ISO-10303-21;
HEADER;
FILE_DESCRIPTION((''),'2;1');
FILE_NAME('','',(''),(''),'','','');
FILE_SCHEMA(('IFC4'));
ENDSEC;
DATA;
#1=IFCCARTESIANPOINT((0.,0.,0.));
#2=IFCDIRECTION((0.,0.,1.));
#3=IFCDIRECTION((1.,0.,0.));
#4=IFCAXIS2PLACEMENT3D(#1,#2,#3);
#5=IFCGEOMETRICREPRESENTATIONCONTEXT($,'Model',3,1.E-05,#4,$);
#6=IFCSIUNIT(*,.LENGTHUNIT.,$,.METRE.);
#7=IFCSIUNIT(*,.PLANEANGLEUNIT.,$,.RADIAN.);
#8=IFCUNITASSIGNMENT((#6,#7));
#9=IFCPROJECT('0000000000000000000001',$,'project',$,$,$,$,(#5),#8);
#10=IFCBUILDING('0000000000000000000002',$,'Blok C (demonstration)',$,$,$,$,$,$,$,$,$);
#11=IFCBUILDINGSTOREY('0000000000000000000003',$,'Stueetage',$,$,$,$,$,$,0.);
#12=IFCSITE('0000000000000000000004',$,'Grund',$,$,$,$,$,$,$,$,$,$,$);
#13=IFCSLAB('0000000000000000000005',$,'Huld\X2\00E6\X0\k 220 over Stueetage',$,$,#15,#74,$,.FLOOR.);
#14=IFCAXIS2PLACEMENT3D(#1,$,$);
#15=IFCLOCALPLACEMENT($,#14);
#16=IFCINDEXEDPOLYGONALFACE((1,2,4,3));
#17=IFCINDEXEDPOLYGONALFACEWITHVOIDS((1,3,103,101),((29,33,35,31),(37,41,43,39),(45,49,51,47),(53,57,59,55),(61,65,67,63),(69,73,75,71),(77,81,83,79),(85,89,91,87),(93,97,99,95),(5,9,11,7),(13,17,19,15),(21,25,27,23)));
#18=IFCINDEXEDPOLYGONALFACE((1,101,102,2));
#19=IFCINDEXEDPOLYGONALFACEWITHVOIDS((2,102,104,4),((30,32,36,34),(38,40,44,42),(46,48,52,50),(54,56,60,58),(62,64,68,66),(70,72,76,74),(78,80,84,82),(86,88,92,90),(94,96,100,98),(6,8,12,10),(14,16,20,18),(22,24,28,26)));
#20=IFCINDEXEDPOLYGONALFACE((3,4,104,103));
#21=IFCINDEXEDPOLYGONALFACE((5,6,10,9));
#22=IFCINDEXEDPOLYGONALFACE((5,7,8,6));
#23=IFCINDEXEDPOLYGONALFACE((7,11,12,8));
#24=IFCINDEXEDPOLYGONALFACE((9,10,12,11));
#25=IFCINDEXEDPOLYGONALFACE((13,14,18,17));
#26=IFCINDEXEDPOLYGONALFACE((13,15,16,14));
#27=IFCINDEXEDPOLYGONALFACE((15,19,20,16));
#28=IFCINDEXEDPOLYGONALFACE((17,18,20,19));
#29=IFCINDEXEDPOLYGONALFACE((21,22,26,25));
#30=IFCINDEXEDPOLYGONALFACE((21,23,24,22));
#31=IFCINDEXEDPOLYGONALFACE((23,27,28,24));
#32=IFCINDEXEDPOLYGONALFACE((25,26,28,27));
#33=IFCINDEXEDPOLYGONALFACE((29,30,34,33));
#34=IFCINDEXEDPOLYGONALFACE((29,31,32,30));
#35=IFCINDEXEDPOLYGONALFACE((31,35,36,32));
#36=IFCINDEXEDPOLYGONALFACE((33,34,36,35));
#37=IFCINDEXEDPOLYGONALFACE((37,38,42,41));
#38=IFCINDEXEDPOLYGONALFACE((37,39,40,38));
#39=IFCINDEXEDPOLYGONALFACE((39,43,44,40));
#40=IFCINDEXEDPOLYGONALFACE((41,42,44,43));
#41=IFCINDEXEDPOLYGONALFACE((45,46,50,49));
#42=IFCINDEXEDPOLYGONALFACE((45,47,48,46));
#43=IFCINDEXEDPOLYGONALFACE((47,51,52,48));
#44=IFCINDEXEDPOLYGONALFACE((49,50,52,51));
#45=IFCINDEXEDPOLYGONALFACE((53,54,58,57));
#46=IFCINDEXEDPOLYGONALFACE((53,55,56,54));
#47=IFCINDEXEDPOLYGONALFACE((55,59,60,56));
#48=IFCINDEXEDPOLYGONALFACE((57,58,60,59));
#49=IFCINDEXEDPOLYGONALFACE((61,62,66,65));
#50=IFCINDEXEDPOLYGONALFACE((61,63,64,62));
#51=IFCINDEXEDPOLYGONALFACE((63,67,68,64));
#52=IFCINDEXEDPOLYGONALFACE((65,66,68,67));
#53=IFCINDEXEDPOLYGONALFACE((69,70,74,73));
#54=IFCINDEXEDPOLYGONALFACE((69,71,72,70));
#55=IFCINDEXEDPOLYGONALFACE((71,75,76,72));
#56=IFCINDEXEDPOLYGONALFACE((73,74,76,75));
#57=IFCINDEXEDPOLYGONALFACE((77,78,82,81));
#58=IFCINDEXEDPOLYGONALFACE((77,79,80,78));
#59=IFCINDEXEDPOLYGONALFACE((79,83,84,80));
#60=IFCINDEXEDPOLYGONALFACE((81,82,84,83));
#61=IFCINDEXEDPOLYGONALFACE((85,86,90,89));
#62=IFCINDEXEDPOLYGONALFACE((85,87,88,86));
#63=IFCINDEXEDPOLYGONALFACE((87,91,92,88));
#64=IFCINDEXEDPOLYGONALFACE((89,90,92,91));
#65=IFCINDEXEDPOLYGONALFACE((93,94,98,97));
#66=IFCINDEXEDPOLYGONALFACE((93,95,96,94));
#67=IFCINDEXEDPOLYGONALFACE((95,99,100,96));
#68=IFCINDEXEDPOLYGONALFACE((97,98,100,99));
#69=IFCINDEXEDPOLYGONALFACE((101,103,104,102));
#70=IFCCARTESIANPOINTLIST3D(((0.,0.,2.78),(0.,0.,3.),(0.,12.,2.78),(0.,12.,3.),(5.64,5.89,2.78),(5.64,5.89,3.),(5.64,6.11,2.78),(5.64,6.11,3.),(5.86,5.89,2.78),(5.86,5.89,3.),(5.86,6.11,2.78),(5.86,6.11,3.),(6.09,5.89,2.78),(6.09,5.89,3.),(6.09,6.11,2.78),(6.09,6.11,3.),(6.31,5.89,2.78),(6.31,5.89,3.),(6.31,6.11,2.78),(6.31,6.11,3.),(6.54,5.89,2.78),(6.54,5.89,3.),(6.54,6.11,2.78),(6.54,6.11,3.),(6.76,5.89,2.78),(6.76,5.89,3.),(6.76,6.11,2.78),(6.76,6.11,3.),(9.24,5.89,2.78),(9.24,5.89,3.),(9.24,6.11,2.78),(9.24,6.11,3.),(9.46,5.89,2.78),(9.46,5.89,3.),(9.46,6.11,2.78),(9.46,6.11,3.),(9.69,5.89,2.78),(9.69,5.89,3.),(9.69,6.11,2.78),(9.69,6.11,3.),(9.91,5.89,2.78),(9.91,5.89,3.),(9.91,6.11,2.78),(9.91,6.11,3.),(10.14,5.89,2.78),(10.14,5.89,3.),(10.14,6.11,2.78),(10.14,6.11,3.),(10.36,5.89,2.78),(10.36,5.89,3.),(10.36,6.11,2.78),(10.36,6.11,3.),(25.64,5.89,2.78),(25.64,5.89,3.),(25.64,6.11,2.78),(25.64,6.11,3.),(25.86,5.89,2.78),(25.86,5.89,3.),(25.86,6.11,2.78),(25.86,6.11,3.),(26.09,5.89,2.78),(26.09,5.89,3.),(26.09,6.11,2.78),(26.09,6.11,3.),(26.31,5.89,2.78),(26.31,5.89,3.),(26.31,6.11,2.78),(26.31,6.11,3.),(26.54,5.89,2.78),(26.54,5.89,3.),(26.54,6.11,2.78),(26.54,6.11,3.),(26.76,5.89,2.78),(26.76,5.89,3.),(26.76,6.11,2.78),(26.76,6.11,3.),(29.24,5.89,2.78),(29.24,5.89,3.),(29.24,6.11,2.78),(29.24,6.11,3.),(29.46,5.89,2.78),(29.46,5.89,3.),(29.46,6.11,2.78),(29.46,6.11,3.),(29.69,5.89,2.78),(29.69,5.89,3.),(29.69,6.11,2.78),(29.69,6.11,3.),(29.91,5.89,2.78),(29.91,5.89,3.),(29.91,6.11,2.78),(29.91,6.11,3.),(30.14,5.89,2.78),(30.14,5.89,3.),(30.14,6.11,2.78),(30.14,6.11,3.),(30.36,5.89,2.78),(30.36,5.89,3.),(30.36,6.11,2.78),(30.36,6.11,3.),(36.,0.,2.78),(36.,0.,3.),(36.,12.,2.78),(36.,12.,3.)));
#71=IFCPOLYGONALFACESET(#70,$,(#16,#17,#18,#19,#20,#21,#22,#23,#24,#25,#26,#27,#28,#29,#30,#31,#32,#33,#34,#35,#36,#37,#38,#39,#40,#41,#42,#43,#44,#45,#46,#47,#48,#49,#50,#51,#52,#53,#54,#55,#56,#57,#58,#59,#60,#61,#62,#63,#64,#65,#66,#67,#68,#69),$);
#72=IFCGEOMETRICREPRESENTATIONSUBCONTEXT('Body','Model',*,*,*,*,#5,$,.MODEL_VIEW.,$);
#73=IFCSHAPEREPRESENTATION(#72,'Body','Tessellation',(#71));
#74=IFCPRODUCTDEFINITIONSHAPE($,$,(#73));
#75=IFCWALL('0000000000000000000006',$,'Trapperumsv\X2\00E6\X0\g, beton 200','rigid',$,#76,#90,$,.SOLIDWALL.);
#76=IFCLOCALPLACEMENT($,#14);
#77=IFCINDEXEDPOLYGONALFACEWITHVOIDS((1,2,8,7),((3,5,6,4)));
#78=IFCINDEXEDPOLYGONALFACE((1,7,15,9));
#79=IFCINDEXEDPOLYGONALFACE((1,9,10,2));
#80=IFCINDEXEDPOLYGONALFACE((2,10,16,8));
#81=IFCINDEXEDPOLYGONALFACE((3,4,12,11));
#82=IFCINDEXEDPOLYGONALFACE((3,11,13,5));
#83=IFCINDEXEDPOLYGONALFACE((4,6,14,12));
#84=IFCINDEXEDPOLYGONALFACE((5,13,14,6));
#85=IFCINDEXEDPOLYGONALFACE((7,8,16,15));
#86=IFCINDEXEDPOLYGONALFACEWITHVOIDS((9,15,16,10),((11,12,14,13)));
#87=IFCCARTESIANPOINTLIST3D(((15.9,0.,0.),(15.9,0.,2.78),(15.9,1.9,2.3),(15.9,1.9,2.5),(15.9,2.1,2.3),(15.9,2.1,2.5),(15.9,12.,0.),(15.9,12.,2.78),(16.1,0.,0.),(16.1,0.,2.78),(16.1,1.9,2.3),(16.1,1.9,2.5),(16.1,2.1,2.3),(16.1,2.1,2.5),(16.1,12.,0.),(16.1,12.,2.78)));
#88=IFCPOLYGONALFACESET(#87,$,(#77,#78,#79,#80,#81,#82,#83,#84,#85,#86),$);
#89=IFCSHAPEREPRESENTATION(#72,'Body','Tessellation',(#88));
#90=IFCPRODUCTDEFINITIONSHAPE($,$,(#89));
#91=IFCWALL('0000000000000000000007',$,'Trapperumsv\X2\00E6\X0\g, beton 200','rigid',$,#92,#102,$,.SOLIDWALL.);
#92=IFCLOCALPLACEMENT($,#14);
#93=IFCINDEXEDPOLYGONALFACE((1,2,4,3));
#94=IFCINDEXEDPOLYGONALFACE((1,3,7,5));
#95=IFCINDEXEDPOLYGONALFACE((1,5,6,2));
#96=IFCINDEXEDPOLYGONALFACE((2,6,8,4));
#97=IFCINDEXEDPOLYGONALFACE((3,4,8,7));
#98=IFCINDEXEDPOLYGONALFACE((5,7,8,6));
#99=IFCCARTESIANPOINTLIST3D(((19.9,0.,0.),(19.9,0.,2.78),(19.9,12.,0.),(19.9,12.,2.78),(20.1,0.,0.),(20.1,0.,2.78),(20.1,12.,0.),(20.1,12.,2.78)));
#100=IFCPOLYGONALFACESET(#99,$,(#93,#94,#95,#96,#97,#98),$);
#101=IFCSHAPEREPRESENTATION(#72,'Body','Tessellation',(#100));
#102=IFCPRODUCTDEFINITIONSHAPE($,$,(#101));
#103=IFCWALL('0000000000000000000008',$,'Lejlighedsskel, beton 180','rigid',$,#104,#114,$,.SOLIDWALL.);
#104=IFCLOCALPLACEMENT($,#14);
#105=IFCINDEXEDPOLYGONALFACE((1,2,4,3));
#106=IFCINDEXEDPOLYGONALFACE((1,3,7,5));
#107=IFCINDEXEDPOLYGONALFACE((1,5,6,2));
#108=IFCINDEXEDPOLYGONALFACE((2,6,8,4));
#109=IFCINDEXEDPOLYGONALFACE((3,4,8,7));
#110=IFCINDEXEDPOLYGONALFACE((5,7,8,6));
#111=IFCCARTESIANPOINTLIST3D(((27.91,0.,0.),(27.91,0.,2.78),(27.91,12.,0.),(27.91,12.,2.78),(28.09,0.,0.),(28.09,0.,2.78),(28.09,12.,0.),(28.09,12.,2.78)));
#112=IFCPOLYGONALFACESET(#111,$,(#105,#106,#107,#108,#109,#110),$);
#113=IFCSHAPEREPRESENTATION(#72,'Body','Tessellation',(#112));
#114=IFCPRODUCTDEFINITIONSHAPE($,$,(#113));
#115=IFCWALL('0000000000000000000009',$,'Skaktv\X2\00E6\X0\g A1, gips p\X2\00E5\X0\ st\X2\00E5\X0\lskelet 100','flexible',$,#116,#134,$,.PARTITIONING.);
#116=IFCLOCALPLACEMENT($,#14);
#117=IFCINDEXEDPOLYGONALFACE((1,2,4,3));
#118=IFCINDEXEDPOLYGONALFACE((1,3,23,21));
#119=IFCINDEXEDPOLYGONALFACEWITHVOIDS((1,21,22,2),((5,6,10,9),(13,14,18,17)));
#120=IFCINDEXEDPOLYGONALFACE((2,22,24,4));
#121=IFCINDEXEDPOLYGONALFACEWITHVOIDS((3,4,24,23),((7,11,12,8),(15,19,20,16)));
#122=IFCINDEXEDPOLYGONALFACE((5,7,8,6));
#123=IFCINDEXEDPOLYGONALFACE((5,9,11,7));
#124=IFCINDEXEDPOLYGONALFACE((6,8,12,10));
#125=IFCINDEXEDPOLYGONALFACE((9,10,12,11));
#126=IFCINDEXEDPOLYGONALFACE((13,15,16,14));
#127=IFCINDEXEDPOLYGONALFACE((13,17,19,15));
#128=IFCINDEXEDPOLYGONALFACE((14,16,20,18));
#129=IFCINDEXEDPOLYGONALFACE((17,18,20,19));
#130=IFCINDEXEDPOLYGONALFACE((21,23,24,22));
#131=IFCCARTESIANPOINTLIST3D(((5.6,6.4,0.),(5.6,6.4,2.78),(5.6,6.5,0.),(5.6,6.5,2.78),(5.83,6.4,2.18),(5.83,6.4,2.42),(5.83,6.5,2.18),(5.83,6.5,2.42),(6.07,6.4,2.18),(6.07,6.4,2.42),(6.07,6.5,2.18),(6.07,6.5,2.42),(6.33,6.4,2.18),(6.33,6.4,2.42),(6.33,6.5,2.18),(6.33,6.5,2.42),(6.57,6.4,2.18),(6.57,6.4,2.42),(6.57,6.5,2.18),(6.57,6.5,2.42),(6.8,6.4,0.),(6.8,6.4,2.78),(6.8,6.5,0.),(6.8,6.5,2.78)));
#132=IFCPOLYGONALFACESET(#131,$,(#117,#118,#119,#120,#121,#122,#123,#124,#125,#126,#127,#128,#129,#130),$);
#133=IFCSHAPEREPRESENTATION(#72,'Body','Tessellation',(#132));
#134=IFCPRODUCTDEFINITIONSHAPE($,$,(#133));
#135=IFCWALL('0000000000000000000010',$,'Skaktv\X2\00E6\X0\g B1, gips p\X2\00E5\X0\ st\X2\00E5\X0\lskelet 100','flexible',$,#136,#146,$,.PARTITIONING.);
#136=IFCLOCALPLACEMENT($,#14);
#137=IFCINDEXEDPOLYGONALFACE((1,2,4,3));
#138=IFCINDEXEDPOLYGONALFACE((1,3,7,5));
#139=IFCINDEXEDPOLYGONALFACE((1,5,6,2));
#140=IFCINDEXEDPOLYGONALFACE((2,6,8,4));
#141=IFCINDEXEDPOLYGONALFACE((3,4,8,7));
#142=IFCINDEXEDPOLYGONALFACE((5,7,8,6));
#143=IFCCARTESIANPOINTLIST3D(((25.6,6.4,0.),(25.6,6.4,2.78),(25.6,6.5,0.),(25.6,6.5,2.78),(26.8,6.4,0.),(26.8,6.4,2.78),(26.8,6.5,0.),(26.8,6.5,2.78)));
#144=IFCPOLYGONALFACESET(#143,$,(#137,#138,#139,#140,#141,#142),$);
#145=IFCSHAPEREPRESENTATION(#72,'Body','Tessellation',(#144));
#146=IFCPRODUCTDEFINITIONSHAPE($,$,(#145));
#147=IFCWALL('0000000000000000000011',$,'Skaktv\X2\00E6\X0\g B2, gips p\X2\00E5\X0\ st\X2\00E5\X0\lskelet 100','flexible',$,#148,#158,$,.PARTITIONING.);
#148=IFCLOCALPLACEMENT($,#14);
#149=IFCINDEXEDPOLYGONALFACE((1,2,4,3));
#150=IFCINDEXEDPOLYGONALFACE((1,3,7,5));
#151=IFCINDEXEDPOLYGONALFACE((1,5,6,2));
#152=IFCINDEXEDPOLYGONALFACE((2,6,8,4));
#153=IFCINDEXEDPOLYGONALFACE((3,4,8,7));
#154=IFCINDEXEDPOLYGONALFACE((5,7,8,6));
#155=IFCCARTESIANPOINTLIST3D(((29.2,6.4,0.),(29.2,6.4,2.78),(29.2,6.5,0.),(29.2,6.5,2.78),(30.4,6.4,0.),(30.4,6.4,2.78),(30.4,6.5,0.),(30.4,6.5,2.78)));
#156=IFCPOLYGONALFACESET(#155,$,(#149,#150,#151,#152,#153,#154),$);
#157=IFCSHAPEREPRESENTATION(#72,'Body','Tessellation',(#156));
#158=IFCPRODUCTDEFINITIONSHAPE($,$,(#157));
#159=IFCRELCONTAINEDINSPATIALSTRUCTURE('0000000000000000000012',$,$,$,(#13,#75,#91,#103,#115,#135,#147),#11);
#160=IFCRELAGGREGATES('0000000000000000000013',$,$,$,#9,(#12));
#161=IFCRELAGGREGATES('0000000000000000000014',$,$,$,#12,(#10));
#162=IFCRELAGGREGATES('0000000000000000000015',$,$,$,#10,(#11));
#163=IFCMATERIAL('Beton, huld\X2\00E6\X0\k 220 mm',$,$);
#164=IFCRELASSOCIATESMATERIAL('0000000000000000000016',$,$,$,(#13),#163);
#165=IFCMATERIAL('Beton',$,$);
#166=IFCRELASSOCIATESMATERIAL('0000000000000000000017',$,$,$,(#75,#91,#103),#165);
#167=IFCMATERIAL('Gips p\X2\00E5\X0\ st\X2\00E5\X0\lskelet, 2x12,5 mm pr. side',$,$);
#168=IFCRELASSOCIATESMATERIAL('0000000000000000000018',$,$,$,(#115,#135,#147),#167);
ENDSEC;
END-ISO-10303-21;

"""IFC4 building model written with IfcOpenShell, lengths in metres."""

from ifc_helpers import new_model, si_unit, frame, origin, origin_with_axes, place, context, subcontext, project, spatial, polyline, outline, extrude, material, element, save


model = new_model("IFC4")

# Units and contexts
model_context = context("Model", 3, precision=1e-05, world=origin_with_axes())
body_context = subcontext(model_context, "Body", "Model", "MODEL_VIEW")
ifc_project = project(units=[si_unit("LENGTHUNIT", "METRE"), si_unit("PLANEANGLEUNIT", "RADIAN")], contexts=[model_context])

# Site, building, storey
site = spatial("IfcSite", under=ifc_project, Name="Grund")
building = spatial("IfcBuilding", under=site, Name="Blok C (demonstration)")
storey = spatial("IfcBuildingStorey", under=building, Name="Stueetage", Elevation=0.0)

# Slab, openings
ifc_material_1 = material(Name="Beton, huldæk 220 mm")
slab_placement = place(None, origin_with_axes())
slab = element("IfcSlab", 1, at=slab_placement, inside=storey, material=ifc_material_1, Name="Huldæk 220 over Stueetage", PredefinedType="FLOOR", context=body_context, shape_type="SweptSolid", body=[
    extrude(outline(polyline([(0.0, 0.0), (36.0, 0.0), (36.0, 12.0), (0.0, 12.0), (0.0, 0.0)])), frame((0.0, 0.0, 2.78)), (0.0, 0.0, 1.0), 0.22),
])
opening_1_placement = place(slab_placement, origin_with_axes())
element("IfcOpeningElement", 2, at=opening_1_placement, cuts=slab, PredefinedType="OPENING", context=body_context, shape_type="SweptSolid", body=[
    extrude(outline(polyline([(5.64, 5.89), (5.86, 5.89), (5.86, 6.11), (5.64, 6.11), (5.64, 5.89)])), frame((0.0, 0.0, 2.77)), (0.0, 0.0, 1.0), 0.24),
])
opening_2_placement = place(slab_placement, origin_with_axes())
element("IfcOpeningElement", 3, at=opening_2_placement, cuts=slab, PredefinedType="OPENING", context=body_context, shape_type="SweptSolid", body=[
    extrude(outline(polyline([(6.09, 5.89), (6.31, 5.89), (6.31, 6.11), (6.09, 6.11), (6.09, 5.89)])), frame((0.0, 0.0, 2.77)), (0.0, 0.0, 1.0), 0.24),
])
opening_3_placement = place(slab_placement, origin_with_axes())
element("IfcOpeningElement", 4, at=opening_3_placement, cuts=slab, PredefinedType="OPENING", context=body_context, shape_type="SweptSolid", body=[
    extrude(outline(polyline([(6.54, 5.89), (6.76, 5.89), (6.76, 6.11), (6.54, 6.11), (6.54, 5.89)])), frame((0.0, 0.0, 2.77)), (0.0, 0.0, 1.0), 0.24),
])
opening_4_placement = place(slab_placement, origin_with_axes())
element("IfcOpeningElement", 5, at=opening_4_placement, cuts=slab, PredefinedType="OPENING", context=body_context, shape_type="SweptSolid", body=[
    extrude(outline(polyline([(9.24, 5.89), (9.46, 5.89), (9.46, 6.11), (9.24, 6.11), (9.24, 5.89)])), frame((0.0, 0.0, 2.77)), (0.0, 0.0, 1.0), 0.24),
])
opening_5_placement = place(slab_placement, origin_with_axes())
element("IfcOpeningElement", 6, at=opening_5_placement, cuts=slab, PredefinedType="OPENING", context=body_context, shape_type="SweptSolid", body=[
    extrude(outline(polyline([(9.69, 5.89), (9.91, 5.89), (9.91, 6.11), (9.69, 6.11), (9.69, 5.89)])), frame((0.0, 0.0, 2.77)), (0.0, 0.0, 1.0), 0.24),
])
opening_6_placement = place(slab_placement, origin_with_axes())
element("IfcOpeningElement", 7, at=opening_6_placement, cuts=slab, PredefinedType="OPENING", context=body_context, shape_type="SweptSolid", body=[
    extrude(outline(polyline([(10.14, 5.89), (10.36, 5.89), (10.36, 6.11), (10.14, 6.11), (10.14, 5.89)])), frame((0.0, 0.0, 2.77)), (0.0, 0.0, 1.0), 0.24),
])
opening_7_placement = place(slab_placement, origin_with_axes())
element("IfcOpeningElement", 8, at=opening_7_placement, cuts=slab, PredefinedType="OPENING", context=body_context, shape_type="SweptSolid", body=[
    extrude(outline(polyline([(25.64, 5.89), (25.86, 5.89), (25.86, 6.11), (25.64, 6.11), (25.64, 5.89)])), frame((0.0, 0.0, 2.77)), (0.0, 0.0, 1.0), 0.24),
])
opening_8_placement = place(slab_placement, origin_with_axes())
element("IfcOpeningElement", 9, at=opening_8_placement, cuts=slab, PredefinedType="OPENING", context=body_context, shape_type="SweptSolid", body=[
    extrude(outline(polyline([(26.09, 5.89), (26.31, 5.89), (26.31, 6.11), (26.09, 6.11), (26.09, 5.89)])), frame((0.0, 0.0, 2.77)), (0.0, 0.0, 1.0), 0.24),
])
opening_9_placement = place(slab_placement, origin_with_axes())
element("IfcOpeningElement", 10, at=opening_9_placement, cuts=slab, PredefinedType="OPENING", context=body_context, shape_type="SweptSolid", body=[
    extrude(outline(polyline([(26.54, 5.89), (26.76, 5.89), (26.76, 6.11), (26.54, 6.11), (26.54, 5.89)])), frame((0.0, 0.0, 2.77)), (0.0, 0.0, 1.0), 0.24),
])
opening_10_placement = place(slab_placement, origin_with_axes())
element("IfcOpeningElement", 11, at=opening_10_placement, cuts=slab, PredefinedType="OPENING", context=body_context, shape_type="SweptSolid", body=[
    extrude(outline(polyline([(29.24, 5.89), (29.46, 5.89), (29.46, 6.11), (29.24, 6.11), (29.24, 5.89)])), frame((0.0, 0.0, 2.77)), (0.0, 0.0, 1.0), 0.24),
])
opening_11_placement = place(slab_placement, origin_with_axes())
element("IfcOpeningElement", 12, at=opening_11_placement, cuts=slab, PredefinedType="OPENING", context=body_context, shape_type="SweptSolid", body=[
    extrude(outline(polyline([(29.69, 5.89), (29.91, 5.89), (29.91, 6.11), (29.69, 6.11), (29.69, 5.89)])), frame((0.0, 0.0, 2.77)), (0.0, 0.0, 1.0), 0.24),
])
opening_12_placement = place(slab_placement, origin_with_axes())
element("IfcOpeningElement", 13, at=opening_12_placement, cuts=slab, PredefinedType="OPENING", context=body_context, shape_type="SweptSolid", body=[
    extrude(outline(polyline([(30.14, 5.89), (30.36, 5.89), (30.36, 6.11), (30.14, 6.11), (30.14, 5.89)])), frame((0.0, 0.0, 2.77)), (0.0, 0.0, 1.0), 0.24),
])

# Wall, opening
ifc_material_2 = material(Name="Beton")
wall_1_placement = place(None, origin_with_axes())
wall_1 = element("IfcWall", 14, at=wall_1_placement, inside=storey, material=ifc_material_2, Name="Trapperumsvæg, beton 200", Description="rigid", PredefinedType="SOLIDWALL", context=body_context, shape_type="SweptSolid", body=[
    extrude(outline(polyline([(15.9, 0.0), (16.1, 0.0), (16.1, 12.0), (15.9, 12.0), (15.9, 0.0)])), origin(), (0.0, 0.0, 1.0), 2.78),
])
opening_13_placement = place(wall_1_placement, origin_with_axes())
element("IfcOpeningElement", 15, at=opening_13_placement, cuts=wall_1, PredefinedType="OPENING", context=body_context, shape_type="SweptSolid", body=[
    extrude(outline(polyline([(15.88, 1.9), (16.12, 1.9), (16.12, 2.1), (15.88, 2.1), (15.88, 1.9)])), frame((0.0, 0.0, 2.3)), (0.0, 0.0, 1.0), 0.2),
])

# Wall
wall_2_placement = place(None, origin_with_axes())
element("IfcWall", 16, at=wall_2_placement, inside=storey, material=ifc_material_2, Name="Trapperumsvæg, beton 200", Description="rigid", PredefinedType="SOLIDWALL", context=body_context, shape_type="SweptSolid", body=[
    extrude(outline(polyline([(19.9, 0.0), (20.1, 0.0), (20.1, 12.0), (19.9, 12.0), (19.9, 0.0)])), origin(), (0.0, 0.0, 1.0), 2.78),
])

# Wall
wall_3_placement = place(None, origin_with_axes())
element("IfcWall", 17, at=wall_3_placement, inside=storey, material=ifc_material_2, Name="Lejlighedsskel, beton 180", Description="rigid", PredefinedType="SOLIDWALL", context=body_context, shape_type="SweptSolid", body=[
    extrude(outline(polyline([(27.91, 0.0), (28.09, 0.0), (28.09, 12.0), (27.91, 12.0), (27.91, 0.0)])), origin(), (0.0, 0.0, 1.0), 2.78),
])

# Wall, openings
ifc_material_3 = material(Name="Gips på stålskelet, 2x12,5 mm pr. side")
wall_4_placement = place(None, origin_with_axes())
wall_4 = element("IfcWall", 18, at=wall_4_placement, inside=storey, material=ifc_material_3, Name="Skaktvæg A1, gips på stålskelet 100", Description="flexible", PredefinedType="PARTITIONING", context=body_context, shape_type="SweptSolid", body=[
    extrude(outline(polyline([(5.6, 6.4), (6.8, 6.4), (6.8, 6.5), (5.6, 6.5), (5.6, 6.4)])), origin(), (0.0, 0.0, 1.0), 2.78),
])
opening_14_placement = place(wall_4_placement, origin_with_axes())
element("IfcOpeningElement", 19, at=opening_14_placement, cuts=wall_4, PredefinedType="OPENING", context=body_context, shape_type="SweptSolid", body=[
    extrude(outline(polyline([(5.83, 6.33), (6.07, 6.33), (6.07, 6.57), (5.83, 6.57), (5.83, 6.33)])), frame((0.0, 0.0, 2.18)), (0.0, 0.0, 1.0), 0.24),
])
opening_15_placement = place(wall_4_placement, origin_with_axes())
element("IfcOpeningElement", 20, at=opening_15_placement, cuts=wall_4, PredefinedType="OPENING", context=body_context, shape_type="SweptSolid", body=[
    extrude(outline(polyline([(6.33, 6.33), (6.57, 6.33), (6.57, 6.57), (6.33, 6.57), (6.33, 6.33)])), frame((0.0, 0.0, 2.18)), (0.0, 0.0, 1.0), 0.24),
])

# Walls
wall_5_placement = place(None, origin_with_axes())
element("IfcWall", 21, at=wall_5_placement, inside=storey, material=ifc_material_3, Name="Skaktvæg B1, gips på stålskelet 100", Description="flexible", PredefinedType="PARTITIONING", context=body_context, shape_type="SweptSolid", body=[
    extrude(outline(polyline([(25.6, 6.4), (26.8, 6.4), (26.8, 6.5), (25.6, 6.5), (25.6, 6.4)])), origin(), (0.0, 0.0, 1.0), 2.78),
])
wall_6_placement = place(None, origin_with_axes())
element("IfcWall", 22, at=wall_6_placement, inside=storey, material=ifc_material_3, Name="Skaktvæg B2, gips på stålskelet 100", Description="flexible", PredefinedType="PARTITIONING", context=body_context, shape_type="SweptSolid", body=[
    extrude(outline(polyline([(29.2, 6.4), (30.4, 6.4), (30.4, 6.5), (29.2, 6.5), (29.2, 6.4)])), origin(), (0.0, 0.0, 1.0), 2.78),
])

save(model, "model.ifc")
